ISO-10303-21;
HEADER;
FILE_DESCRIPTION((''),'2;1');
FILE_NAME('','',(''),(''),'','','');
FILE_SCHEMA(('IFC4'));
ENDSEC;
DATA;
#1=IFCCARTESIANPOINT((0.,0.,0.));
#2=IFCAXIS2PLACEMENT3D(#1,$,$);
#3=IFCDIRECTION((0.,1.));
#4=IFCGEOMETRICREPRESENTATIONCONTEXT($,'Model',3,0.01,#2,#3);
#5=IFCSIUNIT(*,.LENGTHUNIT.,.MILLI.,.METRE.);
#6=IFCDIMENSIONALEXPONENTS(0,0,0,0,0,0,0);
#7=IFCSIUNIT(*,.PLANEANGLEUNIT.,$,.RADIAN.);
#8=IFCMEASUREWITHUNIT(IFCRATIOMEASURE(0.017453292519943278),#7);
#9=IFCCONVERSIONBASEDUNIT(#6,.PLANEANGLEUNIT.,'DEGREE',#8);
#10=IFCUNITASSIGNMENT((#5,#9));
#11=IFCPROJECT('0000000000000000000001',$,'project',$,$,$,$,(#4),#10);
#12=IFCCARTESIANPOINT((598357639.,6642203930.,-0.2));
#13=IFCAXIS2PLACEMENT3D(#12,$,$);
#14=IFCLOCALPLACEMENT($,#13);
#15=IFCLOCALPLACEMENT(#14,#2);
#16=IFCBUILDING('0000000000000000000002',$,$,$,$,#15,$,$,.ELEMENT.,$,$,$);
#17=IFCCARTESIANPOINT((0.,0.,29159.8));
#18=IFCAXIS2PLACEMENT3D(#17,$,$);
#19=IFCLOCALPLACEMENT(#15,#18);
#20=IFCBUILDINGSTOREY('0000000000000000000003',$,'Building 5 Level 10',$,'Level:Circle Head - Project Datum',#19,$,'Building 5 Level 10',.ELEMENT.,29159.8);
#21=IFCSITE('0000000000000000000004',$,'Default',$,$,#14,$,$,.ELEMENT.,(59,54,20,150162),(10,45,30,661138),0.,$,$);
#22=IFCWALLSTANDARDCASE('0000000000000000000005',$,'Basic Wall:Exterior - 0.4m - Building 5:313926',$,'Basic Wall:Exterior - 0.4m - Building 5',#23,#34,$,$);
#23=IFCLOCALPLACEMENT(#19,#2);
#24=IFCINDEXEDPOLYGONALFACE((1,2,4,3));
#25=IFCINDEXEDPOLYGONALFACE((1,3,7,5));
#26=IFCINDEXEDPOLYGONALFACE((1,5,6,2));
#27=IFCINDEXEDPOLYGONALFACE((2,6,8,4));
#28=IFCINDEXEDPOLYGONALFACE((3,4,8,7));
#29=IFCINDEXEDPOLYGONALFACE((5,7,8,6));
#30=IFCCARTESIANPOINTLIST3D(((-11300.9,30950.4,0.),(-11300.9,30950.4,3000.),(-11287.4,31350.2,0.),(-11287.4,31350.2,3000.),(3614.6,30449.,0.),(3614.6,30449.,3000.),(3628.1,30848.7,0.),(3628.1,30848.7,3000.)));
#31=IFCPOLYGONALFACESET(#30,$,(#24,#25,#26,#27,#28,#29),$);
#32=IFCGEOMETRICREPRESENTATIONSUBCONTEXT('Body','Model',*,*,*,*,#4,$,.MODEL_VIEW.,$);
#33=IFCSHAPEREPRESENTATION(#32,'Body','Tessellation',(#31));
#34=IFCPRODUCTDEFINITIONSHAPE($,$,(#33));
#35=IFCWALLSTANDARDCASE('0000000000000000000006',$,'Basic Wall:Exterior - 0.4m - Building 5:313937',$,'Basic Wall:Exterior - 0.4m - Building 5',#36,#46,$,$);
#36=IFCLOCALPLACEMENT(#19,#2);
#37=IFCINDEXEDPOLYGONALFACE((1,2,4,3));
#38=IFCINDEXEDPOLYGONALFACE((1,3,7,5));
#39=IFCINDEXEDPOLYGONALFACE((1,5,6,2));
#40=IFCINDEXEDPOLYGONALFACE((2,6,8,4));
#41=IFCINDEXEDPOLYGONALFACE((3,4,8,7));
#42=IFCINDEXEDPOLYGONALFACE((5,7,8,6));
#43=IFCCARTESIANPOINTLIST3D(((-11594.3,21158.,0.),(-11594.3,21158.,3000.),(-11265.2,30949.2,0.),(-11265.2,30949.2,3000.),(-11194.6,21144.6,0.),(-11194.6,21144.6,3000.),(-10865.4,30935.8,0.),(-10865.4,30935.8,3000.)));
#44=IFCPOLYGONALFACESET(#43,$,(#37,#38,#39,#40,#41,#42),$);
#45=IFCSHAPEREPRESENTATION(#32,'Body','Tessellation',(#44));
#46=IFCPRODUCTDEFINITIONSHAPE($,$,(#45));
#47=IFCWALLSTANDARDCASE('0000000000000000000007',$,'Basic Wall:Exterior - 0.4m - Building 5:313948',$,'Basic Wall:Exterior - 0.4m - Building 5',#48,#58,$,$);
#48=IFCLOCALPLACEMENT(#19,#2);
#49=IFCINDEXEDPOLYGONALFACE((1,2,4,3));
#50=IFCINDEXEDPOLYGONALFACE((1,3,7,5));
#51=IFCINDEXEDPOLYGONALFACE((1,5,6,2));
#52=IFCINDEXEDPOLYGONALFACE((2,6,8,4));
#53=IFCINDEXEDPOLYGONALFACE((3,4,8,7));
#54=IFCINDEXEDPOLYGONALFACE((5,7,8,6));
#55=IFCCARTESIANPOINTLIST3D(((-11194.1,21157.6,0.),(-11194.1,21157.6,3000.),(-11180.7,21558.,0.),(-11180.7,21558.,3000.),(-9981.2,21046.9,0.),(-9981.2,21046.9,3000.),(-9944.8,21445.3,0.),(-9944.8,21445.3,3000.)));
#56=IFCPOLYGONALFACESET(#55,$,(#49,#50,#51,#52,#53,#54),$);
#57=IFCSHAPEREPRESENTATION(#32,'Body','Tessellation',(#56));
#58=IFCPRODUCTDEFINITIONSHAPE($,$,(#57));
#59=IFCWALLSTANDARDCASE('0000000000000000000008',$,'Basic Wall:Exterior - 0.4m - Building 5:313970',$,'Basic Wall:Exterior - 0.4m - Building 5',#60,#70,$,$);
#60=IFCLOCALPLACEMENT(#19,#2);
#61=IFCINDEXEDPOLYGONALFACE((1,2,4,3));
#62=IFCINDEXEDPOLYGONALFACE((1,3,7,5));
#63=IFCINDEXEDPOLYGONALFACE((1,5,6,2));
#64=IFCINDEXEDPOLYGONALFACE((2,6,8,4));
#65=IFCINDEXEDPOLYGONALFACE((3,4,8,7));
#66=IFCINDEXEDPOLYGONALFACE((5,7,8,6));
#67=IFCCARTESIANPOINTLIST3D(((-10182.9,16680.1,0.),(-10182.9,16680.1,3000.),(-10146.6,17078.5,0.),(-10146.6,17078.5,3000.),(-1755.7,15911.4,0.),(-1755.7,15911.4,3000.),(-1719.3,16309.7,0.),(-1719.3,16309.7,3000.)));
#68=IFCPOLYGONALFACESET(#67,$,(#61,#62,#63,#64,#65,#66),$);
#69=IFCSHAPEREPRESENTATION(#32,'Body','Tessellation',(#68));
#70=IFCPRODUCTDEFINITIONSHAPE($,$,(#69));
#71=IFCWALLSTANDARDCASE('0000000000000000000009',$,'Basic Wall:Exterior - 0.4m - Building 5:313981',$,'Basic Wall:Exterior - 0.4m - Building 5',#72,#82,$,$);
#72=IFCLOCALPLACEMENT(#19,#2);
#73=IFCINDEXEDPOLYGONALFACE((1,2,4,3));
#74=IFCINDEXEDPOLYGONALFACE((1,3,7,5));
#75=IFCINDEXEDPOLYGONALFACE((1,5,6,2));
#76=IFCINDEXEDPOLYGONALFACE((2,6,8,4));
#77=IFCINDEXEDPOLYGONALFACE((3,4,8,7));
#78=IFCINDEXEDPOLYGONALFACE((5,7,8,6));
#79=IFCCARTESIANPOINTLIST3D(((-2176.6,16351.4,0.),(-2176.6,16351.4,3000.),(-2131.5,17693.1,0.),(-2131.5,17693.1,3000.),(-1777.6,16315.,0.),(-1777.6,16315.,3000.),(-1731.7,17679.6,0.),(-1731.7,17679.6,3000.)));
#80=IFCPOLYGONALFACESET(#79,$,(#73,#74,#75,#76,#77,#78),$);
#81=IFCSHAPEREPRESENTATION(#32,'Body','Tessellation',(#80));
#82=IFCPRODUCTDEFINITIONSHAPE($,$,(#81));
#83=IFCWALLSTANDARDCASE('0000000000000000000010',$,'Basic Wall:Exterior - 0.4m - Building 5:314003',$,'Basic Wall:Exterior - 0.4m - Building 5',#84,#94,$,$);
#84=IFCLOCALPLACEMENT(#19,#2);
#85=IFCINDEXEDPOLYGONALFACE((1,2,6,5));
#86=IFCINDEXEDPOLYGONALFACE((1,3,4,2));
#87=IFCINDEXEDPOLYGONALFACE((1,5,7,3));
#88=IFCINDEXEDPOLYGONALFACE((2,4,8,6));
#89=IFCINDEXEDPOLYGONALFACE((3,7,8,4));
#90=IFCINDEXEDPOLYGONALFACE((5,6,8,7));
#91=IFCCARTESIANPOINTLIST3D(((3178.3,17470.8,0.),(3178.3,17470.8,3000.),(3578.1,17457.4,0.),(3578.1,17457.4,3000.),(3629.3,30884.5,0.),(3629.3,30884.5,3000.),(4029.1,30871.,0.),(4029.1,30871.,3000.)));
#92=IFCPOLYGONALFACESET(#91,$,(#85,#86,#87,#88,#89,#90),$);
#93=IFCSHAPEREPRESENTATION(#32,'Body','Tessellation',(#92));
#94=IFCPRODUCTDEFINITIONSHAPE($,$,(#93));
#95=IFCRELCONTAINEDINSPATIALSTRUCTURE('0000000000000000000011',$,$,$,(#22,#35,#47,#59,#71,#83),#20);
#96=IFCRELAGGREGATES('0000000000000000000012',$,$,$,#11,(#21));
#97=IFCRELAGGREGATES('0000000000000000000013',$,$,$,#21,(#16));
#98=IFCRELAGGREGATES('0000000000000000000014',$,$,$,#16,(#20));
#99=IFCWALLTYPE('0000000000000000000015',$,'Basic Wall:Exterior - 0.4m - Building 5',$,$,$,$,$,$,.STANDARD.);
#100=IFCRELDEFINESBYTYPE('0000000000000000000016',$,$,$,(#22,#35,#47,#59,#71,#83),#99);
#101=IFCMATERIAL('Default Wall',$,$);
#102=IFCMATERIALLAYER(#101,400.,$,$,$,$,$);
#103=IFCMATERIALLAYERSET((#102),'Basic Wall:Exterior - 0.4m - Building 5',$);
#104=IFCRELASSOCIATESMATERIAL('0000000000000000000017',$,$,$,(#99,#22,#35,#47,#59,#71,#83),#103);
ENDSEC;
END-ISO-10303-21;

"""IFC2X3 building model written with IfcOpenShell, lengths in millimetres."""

from ifc_helpers import new_model, entity, si_unit, converted_unit, direction, frame, frame_2d, origin, place, context, subcontext, project, spatial, polyline, rectangle, outline, extrude, material, layer, layer_set, layer_usage, type_object, element, save


model = new_model("IFC2X3")

# Units and contexts
model_context = context("Model", 3, precision=0.01, world=origin(), true_north=direction((0.0, 1.0)))
body_context = subcontext(model_context, "Body", "Model", "MODEL_VIEW")
ifc_project = project(units=[si_unit("LENGTHUNIT", "METRE", prefix="MILLI"), converted_unit("PLANEANGLEUNIT", "DEGREE", entity("IfcRatioMeasure", 0.017453292519943278), si_unit("PLANEANGLEUNIT", "RADIAN"), dimensions=[0, 0, 0, 0, 0, 0, 0])], contexts=[model_context])

# Site, building, storey
site_placement = place(None, frame((598357639.0, 6642203930.0, -0.2)))
site = spatial("IfcSite", under=ifc_project, at=site_placement, Name="Default", CompositionType="ELEMENT", RefLatitude=(59, 54, 20, 150162), RefLongitude=(10, 45, 30, 661138), RefElevation=0.0)
building_placement = place(site_placement, origin())
building = spatial("IfcBuilding", under=site, at=building_placement, CompositionType="ELEMENT")
storey_placement = place(building_placement, frame((0.0, 0.0, 29159.8)))
storey = spatial("IfcBuildingStorey", under=building, at=storey_placement, Name="Building 5 Level 10", ObjectType="Level:Circle Head - Project Datum", LongName="Building 5 Level 10", CompositionType="ELEMENT", Elevation=29159.8)

# Walls
ifc_material_1 = material(Name="Default Wall")
ifc_layer_1 = layer(ifc_material_1, 400.0)
ifc_layer_set_1 = layer_set([ifc_layer_1], Name="Basic Wall:Exterior - 0.4m - Building 5")
ifc_layer_usage_1 = layer_usage(ifc_layer_set_1, "AXIS2", "POSITIVE", -200.0)
wall_type = type_object("IfcWallType", Name="Basic Wall:Exterior - 0.4m - Building 5", PredefinedType="STANDARD", material=ifc_layer_set_1)
wall_1_placement = place(storey_placement, frame((3621.4, 30648.9, 0.0), z_axis=(0.0, 0.0, 1.0), x_axis=(-0.999435, 0.033601, 0.0)))
element("IfcWallStandardCase", 1, at=wall_1_placement, inside=storey, type_object=wall_type, material=ifc_layer_usage_1, Name="Basic Wall:Exterior - 0.4m - Building 5:313926", ObjectType="Basic Wall:Exterior - 0.4m - Building 5", context=body_context, shape_type="SweptSolid", body=[
    extrude(rectangle(XDim=14923.9, YDim=400.0, at=frame_2d((7462.0, 0.0), x_axis=(-1.0, 0.0))), origin(), (0.0, 0.0, 1.0), 3000.0),
])
wall_2_placement = place(storey_placement, frame((-11065.3, 30942.5, 0.0), z_axis=(0.0, 0.0, 1.0), x_axis=(-0.033601, -0.999435, 0.0)))
element("IfcWallStandardCase", 2, at=wall_2_placement, inside=storey, type_object=wall_type, material=ifc_layer_usage_1, Name="Basic Wall:Exterior - 0.4m - Building 5:313937", ObjectType="Basic Wall:Exterior - 0.4m - Building 5", context=body_context, shape_type="SweptSolid", body=[
    extrude(rectangle(XDim=9796.7, YDim=400.0, at=frame_2d((4898.4, 0.0), x_axis=(-1.0, 0.0))), origin(), (0.0, 0.0, 1.0), 3000.0),
])
wall_3_placement = place(storey_placement, frame((-11198.8, 21358.8, 0.0), z_axis=(0.0, 0.0, 1.0), x_axis=(0.995865, -0.090846, 0.0)))
element("IfcWallStandardCase", 3, at=wall_3_placement, inside=storey, type_object=wall_type, material=ifc_layer_usage_1, Name="Basic Wall:Exterior - 0.4m - Building 5:313948", ObjectType="Basic Wall:Exterior - 0.4m - Building 5", context=body_context, shape_type="SweptSolid", body=[
    extrude(outline(polyline([(1241.0, -200.0), (1241.0, 200.0), (0.0, 200.0), (23.0, -200.0), (1241.0, -200.0)])), origin(), (0.0, 0.0, 1.0), 3000.0),
])
wall_4_placement = place(storey_placement, frame((-10164.7, 16879.3, 0.0), z_axis=(0.0, 0.0, 1.0), x_axis=(0.995865, -0.090846, 0.0)))
element("IfcWallStandardCase", 4, at=wall_4_placement, inside=storey, type_object=wall_type, material=ifc_layer_usage_1, Name="Basic Wall:Exterior - 0.4m - Building 5:313970", ObjectType="Basic Wall:Exterior - 0.4m - Building 5", context=body_context, shape_type="SweptSolid", body=[
    extrude(rectangle(XDim=8462.2, YDim=400.0, at=frame_2d((4231.1, 0.0), x_axis=(-1.0, 0.0))), origin(), (0.0, 0.0, 1.0), 3000.0),
])
wall_5_placement = place(storey_placement, frame((-1977.5, 16321.8, 0.0), z_axis=(0.0, 0.0, 1.0), x_axis=(0.033601, 0.999435, 0.0)))
element("IfcWallStandardCase", 5, at=wall_5_placement, inside=storey, type_object=wall_type, material=ifc_layer_usage_1, Name="Basic Wall:Exterior - 0.4m - Building 5:313981", ObjectType="Basic Wall:Exterior - 0.4m - Building 5", context=body_context, shape_type="SweptSolid", body=[
    extrude(outline(polyline([(1365.3, -200.0), (1365.3, 200.0), (23.0, 200.0), (0.0, -200.0), (1365.3, -200.0)])), origin(), (0.0, 0.0, 1.0), 3000.0),
])
wall_6_placement = place(storey_placement, frame((3378.2, 17464.1, 0.0), z_axis=(0.0, 0.0, 1.0), x_axis=(0.033601, 0.999435, 0.0)))
element("IfcWallStandardCase", 6, at=wall_6_placement, inside=storey, type_object=wall_type, material=ifc_layer_usage_1, Name="Basic Wall:Exterior - 0.4m - Building 5:314003", ObjectType="Basic Wall:Exterior - 0.4m - Building 5", context=body_context, shape_type="SweptSolid", body=[
    extrude(rectangle(XDim=13421.2, YDim=400.0, at=frame_2d((6710.6, 0.0), x_axis=(-1.0, 0.0))), origin(), (0.0, 0.0, 1.0), 3000.0),
])

save(model, "model.ifc")
